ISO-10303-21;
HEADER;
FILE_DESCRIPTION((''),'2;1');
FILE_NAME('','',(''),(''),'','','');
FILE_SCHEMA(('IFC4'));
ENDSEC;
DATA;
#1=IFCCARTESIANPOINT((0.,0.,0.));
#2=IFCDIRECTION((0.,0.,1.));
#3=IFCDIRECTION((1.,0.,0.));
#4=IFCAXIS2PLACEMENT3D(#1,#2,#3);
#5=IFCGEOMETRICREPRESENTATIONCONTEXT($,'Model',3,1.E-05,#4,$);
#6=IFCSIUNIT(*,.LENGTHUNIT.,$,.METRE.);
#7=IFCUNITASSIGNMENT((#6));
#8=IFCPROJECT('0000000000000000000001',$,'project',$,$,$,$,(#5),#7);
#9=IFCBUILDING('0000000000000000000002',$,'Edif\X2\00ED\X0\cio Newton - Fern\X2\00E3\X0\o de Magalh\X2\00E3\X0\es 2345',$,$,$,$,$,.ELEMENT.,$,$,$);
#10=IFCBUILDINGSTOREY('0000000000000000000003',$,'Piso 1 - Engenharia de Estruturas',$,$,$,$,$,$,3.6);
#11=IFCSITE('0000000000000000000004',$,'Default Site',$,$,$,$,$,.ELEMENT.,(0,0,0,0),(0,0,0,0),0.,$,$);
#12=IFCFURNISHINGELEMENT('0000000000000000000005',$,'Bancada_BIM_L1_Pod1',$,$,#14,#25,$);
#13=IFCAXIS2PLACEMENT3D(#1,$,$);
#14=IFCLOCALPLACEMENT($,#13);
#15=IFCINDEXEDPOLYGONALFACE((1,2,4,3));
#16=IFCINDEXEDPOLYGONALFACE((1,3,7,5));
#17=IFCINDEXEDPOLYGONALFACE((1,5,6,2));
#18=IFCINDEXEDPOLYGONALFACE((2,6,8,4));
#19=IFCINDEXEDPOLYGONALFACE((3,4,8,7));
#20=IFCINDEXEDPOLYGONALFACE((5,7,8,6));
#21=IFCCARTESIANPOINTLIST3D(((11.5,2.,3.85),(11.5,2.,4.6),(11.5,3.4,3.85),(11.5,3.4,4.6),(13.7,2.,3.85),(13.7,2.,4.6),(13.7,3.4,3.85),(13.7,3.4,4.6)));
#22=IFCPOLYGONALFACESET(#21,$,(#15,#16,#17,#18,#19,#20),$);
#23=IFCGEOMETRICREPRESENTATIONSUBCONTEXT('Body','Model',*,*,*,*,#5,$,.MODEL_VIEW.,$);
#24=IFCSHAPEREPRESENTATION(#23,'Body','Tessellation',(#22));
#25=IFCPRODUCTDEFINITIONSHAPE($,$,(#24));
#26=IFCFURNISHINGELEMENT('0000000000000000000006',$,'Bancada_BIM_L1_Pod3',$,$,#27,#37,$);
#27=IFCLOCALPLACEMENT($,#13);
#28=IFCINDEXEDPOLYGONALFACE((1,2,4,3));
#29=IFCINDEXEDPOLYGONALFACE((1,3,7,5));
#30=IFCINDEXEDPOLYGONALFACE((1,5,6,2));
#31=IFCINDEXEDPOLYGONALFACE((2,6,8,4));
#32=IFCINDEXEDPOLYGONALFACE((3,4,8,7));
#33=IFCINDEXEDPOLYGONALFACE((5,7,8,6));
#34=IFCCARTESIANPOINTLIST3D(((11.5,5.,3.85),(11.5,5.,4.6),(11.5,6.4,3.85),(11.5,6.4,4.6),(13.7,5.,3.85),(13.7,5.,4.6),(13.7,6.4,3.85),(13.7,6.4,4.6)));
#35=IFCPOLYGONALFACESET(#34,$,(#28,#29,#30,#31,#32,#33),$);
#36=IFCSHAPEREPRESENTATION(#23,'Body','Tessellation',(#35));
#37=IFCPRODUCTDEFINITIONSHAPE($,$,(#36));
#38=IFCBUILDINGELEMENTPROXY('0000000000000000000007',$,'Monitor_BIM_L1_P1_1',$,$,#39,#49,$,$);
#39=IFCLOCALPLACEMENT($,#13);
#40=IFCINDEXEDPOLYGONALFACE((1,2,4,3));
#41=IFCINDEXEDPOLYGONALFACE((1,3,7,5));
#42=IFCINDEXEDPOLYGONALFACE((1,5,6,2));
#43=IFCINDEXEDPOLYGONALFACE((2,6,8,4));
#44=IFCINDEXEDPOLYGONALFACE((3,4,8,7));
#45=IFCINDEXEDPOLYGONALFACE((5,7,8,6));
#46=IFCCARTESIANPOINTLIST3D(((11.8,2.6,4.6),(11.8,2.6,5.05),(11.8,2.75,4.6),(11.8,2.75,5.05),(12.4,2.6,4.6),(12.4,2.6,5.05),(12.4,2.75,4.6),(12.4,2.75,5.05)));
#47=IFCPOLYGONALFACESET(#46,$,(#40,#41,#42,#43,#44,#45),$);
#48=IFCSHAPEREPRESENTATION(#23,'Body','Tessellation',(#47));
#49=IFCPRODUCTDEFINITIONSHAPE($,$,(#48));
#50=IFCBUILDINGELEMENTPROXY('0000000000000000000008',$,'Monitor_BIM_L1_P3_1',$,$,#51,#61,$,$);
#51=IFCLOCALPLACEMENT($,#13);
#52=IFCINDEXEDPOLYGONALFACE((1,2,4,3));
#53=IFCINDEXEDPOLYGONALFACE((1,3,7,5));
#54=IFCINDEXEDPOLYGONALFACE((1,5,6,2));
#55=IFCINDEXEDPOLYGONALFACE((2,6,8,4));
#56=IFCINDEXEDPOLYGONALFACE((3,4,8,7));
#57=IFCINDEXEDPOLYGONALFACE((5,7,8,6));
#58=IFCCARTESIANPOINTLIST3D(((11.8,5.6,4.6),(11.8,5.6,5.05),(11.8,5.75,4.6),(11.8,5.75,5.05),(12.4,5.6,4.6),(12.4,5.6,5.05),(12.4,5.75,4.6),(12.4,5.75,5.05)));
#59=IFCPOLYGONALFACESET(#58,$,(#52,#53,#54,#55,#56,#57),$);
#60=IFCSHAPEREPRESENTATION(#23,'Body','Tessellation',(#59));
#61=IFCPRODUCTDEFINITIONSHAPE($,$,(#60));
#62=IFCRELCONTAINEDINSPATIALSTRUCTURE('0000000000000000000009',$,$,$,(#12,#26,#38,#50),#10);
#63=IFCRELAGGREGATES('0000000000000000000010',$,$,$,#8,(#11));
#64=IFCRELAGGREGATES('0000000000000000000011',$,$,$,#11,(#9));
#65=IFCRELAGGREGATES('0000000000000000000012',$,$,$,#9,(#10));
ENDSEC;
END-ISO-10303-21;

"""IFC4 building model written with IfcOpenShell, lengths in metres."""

from ifc_helpers import new_model, si_unit, frame, frame_2d, origin_with_axes, place, context, subcontext, project, spatial, rectangle, extrude, element, save


model = new_model("IFC4")

# Units and contexts
model_context = context("Model", 3, precision=1e-05, world=origin_with_axes())
body_context = subcontext(model_context, "Body", "Model", "MODEL_VIEW")
ifc_project = project(units=[si_unit("LENGTHUNIT", "METRE")], contexts=[model_context])

# Site, building, storey
site = spatial("IfcSite", under=ifc_project, Name="Default Site", CompositionType="ELEMENT", RefLatitude=(0, 0, 0, 0), RefLongitude=(0, 0, 0, 0), RefElevation=0.0)
building = spatial("IfcBuilding", under=site, Name="Edifício Newton - Fernão de Magalhães 2345", CompositionType="ELEMENT")
storey = spatial("IfcBuildingStorey", under=building, Name="Piso 1 - Engenharia de Estruturas", Elevation=3.6)

# Furnishing elements
for number, where, z_axis, x_axis, name in (
    (1, (11.5, 2.0, 3.85), (0.0, 0.0, 1.0), (1.0, 0.0, 0.0), "Bancada_BIM_L1_Pod1"),
    (2, (11.5, 5.0, 3.85), (0.0, 0.0, 1.0), (1.0, 0.0, 0.0), "Bancada_BIM_L1_Pod3"),
):
    element("IfcFurnishingElement", number, at=place(None, frame(where, z_axis=z_axis, x_axis=x_axis)), inside=storey, Name=name, context=body_context, shape_type="SweptSolid", body=[
        extrude(rectangle(XDim=2.2, YDim=1.4, at=frame_2d((1.1, 0.7))), origin_with_axes(), (0.0, 0.0, 1.0), 0.75),
    ])

# Building element proxies
for number, where, z_axis, x_axis, name in (
    (3, (11.8, 2.6, 4.6), (0.0, 0.0, 1.0), (1.0, 0.0, 0.0), "Monitor_BIM_L1_P1_1"),
    (4, (11.8, 5.6, 4.6), (0.0, 0.0, 1.0), (1.0, 0.0, 0.0), "Monitor_BIM_L1_P3_1"),
):
    element("IfcBuildingElementProxy", number, at=place(None, frame(where, z_axis=z_axis, x_axis=x_axis)), inside=storey, Name=name, context=body_context, shape_type="SweptSolid", body=[
        extrude(rectangle(XDim=0.6, YDim=0.15, at=frame_2d((0.3, 0.075))), origin_with_axes(), (0.0, 0.0, 1.0), 0.45),
    ])

save(model, "model.ifc")
